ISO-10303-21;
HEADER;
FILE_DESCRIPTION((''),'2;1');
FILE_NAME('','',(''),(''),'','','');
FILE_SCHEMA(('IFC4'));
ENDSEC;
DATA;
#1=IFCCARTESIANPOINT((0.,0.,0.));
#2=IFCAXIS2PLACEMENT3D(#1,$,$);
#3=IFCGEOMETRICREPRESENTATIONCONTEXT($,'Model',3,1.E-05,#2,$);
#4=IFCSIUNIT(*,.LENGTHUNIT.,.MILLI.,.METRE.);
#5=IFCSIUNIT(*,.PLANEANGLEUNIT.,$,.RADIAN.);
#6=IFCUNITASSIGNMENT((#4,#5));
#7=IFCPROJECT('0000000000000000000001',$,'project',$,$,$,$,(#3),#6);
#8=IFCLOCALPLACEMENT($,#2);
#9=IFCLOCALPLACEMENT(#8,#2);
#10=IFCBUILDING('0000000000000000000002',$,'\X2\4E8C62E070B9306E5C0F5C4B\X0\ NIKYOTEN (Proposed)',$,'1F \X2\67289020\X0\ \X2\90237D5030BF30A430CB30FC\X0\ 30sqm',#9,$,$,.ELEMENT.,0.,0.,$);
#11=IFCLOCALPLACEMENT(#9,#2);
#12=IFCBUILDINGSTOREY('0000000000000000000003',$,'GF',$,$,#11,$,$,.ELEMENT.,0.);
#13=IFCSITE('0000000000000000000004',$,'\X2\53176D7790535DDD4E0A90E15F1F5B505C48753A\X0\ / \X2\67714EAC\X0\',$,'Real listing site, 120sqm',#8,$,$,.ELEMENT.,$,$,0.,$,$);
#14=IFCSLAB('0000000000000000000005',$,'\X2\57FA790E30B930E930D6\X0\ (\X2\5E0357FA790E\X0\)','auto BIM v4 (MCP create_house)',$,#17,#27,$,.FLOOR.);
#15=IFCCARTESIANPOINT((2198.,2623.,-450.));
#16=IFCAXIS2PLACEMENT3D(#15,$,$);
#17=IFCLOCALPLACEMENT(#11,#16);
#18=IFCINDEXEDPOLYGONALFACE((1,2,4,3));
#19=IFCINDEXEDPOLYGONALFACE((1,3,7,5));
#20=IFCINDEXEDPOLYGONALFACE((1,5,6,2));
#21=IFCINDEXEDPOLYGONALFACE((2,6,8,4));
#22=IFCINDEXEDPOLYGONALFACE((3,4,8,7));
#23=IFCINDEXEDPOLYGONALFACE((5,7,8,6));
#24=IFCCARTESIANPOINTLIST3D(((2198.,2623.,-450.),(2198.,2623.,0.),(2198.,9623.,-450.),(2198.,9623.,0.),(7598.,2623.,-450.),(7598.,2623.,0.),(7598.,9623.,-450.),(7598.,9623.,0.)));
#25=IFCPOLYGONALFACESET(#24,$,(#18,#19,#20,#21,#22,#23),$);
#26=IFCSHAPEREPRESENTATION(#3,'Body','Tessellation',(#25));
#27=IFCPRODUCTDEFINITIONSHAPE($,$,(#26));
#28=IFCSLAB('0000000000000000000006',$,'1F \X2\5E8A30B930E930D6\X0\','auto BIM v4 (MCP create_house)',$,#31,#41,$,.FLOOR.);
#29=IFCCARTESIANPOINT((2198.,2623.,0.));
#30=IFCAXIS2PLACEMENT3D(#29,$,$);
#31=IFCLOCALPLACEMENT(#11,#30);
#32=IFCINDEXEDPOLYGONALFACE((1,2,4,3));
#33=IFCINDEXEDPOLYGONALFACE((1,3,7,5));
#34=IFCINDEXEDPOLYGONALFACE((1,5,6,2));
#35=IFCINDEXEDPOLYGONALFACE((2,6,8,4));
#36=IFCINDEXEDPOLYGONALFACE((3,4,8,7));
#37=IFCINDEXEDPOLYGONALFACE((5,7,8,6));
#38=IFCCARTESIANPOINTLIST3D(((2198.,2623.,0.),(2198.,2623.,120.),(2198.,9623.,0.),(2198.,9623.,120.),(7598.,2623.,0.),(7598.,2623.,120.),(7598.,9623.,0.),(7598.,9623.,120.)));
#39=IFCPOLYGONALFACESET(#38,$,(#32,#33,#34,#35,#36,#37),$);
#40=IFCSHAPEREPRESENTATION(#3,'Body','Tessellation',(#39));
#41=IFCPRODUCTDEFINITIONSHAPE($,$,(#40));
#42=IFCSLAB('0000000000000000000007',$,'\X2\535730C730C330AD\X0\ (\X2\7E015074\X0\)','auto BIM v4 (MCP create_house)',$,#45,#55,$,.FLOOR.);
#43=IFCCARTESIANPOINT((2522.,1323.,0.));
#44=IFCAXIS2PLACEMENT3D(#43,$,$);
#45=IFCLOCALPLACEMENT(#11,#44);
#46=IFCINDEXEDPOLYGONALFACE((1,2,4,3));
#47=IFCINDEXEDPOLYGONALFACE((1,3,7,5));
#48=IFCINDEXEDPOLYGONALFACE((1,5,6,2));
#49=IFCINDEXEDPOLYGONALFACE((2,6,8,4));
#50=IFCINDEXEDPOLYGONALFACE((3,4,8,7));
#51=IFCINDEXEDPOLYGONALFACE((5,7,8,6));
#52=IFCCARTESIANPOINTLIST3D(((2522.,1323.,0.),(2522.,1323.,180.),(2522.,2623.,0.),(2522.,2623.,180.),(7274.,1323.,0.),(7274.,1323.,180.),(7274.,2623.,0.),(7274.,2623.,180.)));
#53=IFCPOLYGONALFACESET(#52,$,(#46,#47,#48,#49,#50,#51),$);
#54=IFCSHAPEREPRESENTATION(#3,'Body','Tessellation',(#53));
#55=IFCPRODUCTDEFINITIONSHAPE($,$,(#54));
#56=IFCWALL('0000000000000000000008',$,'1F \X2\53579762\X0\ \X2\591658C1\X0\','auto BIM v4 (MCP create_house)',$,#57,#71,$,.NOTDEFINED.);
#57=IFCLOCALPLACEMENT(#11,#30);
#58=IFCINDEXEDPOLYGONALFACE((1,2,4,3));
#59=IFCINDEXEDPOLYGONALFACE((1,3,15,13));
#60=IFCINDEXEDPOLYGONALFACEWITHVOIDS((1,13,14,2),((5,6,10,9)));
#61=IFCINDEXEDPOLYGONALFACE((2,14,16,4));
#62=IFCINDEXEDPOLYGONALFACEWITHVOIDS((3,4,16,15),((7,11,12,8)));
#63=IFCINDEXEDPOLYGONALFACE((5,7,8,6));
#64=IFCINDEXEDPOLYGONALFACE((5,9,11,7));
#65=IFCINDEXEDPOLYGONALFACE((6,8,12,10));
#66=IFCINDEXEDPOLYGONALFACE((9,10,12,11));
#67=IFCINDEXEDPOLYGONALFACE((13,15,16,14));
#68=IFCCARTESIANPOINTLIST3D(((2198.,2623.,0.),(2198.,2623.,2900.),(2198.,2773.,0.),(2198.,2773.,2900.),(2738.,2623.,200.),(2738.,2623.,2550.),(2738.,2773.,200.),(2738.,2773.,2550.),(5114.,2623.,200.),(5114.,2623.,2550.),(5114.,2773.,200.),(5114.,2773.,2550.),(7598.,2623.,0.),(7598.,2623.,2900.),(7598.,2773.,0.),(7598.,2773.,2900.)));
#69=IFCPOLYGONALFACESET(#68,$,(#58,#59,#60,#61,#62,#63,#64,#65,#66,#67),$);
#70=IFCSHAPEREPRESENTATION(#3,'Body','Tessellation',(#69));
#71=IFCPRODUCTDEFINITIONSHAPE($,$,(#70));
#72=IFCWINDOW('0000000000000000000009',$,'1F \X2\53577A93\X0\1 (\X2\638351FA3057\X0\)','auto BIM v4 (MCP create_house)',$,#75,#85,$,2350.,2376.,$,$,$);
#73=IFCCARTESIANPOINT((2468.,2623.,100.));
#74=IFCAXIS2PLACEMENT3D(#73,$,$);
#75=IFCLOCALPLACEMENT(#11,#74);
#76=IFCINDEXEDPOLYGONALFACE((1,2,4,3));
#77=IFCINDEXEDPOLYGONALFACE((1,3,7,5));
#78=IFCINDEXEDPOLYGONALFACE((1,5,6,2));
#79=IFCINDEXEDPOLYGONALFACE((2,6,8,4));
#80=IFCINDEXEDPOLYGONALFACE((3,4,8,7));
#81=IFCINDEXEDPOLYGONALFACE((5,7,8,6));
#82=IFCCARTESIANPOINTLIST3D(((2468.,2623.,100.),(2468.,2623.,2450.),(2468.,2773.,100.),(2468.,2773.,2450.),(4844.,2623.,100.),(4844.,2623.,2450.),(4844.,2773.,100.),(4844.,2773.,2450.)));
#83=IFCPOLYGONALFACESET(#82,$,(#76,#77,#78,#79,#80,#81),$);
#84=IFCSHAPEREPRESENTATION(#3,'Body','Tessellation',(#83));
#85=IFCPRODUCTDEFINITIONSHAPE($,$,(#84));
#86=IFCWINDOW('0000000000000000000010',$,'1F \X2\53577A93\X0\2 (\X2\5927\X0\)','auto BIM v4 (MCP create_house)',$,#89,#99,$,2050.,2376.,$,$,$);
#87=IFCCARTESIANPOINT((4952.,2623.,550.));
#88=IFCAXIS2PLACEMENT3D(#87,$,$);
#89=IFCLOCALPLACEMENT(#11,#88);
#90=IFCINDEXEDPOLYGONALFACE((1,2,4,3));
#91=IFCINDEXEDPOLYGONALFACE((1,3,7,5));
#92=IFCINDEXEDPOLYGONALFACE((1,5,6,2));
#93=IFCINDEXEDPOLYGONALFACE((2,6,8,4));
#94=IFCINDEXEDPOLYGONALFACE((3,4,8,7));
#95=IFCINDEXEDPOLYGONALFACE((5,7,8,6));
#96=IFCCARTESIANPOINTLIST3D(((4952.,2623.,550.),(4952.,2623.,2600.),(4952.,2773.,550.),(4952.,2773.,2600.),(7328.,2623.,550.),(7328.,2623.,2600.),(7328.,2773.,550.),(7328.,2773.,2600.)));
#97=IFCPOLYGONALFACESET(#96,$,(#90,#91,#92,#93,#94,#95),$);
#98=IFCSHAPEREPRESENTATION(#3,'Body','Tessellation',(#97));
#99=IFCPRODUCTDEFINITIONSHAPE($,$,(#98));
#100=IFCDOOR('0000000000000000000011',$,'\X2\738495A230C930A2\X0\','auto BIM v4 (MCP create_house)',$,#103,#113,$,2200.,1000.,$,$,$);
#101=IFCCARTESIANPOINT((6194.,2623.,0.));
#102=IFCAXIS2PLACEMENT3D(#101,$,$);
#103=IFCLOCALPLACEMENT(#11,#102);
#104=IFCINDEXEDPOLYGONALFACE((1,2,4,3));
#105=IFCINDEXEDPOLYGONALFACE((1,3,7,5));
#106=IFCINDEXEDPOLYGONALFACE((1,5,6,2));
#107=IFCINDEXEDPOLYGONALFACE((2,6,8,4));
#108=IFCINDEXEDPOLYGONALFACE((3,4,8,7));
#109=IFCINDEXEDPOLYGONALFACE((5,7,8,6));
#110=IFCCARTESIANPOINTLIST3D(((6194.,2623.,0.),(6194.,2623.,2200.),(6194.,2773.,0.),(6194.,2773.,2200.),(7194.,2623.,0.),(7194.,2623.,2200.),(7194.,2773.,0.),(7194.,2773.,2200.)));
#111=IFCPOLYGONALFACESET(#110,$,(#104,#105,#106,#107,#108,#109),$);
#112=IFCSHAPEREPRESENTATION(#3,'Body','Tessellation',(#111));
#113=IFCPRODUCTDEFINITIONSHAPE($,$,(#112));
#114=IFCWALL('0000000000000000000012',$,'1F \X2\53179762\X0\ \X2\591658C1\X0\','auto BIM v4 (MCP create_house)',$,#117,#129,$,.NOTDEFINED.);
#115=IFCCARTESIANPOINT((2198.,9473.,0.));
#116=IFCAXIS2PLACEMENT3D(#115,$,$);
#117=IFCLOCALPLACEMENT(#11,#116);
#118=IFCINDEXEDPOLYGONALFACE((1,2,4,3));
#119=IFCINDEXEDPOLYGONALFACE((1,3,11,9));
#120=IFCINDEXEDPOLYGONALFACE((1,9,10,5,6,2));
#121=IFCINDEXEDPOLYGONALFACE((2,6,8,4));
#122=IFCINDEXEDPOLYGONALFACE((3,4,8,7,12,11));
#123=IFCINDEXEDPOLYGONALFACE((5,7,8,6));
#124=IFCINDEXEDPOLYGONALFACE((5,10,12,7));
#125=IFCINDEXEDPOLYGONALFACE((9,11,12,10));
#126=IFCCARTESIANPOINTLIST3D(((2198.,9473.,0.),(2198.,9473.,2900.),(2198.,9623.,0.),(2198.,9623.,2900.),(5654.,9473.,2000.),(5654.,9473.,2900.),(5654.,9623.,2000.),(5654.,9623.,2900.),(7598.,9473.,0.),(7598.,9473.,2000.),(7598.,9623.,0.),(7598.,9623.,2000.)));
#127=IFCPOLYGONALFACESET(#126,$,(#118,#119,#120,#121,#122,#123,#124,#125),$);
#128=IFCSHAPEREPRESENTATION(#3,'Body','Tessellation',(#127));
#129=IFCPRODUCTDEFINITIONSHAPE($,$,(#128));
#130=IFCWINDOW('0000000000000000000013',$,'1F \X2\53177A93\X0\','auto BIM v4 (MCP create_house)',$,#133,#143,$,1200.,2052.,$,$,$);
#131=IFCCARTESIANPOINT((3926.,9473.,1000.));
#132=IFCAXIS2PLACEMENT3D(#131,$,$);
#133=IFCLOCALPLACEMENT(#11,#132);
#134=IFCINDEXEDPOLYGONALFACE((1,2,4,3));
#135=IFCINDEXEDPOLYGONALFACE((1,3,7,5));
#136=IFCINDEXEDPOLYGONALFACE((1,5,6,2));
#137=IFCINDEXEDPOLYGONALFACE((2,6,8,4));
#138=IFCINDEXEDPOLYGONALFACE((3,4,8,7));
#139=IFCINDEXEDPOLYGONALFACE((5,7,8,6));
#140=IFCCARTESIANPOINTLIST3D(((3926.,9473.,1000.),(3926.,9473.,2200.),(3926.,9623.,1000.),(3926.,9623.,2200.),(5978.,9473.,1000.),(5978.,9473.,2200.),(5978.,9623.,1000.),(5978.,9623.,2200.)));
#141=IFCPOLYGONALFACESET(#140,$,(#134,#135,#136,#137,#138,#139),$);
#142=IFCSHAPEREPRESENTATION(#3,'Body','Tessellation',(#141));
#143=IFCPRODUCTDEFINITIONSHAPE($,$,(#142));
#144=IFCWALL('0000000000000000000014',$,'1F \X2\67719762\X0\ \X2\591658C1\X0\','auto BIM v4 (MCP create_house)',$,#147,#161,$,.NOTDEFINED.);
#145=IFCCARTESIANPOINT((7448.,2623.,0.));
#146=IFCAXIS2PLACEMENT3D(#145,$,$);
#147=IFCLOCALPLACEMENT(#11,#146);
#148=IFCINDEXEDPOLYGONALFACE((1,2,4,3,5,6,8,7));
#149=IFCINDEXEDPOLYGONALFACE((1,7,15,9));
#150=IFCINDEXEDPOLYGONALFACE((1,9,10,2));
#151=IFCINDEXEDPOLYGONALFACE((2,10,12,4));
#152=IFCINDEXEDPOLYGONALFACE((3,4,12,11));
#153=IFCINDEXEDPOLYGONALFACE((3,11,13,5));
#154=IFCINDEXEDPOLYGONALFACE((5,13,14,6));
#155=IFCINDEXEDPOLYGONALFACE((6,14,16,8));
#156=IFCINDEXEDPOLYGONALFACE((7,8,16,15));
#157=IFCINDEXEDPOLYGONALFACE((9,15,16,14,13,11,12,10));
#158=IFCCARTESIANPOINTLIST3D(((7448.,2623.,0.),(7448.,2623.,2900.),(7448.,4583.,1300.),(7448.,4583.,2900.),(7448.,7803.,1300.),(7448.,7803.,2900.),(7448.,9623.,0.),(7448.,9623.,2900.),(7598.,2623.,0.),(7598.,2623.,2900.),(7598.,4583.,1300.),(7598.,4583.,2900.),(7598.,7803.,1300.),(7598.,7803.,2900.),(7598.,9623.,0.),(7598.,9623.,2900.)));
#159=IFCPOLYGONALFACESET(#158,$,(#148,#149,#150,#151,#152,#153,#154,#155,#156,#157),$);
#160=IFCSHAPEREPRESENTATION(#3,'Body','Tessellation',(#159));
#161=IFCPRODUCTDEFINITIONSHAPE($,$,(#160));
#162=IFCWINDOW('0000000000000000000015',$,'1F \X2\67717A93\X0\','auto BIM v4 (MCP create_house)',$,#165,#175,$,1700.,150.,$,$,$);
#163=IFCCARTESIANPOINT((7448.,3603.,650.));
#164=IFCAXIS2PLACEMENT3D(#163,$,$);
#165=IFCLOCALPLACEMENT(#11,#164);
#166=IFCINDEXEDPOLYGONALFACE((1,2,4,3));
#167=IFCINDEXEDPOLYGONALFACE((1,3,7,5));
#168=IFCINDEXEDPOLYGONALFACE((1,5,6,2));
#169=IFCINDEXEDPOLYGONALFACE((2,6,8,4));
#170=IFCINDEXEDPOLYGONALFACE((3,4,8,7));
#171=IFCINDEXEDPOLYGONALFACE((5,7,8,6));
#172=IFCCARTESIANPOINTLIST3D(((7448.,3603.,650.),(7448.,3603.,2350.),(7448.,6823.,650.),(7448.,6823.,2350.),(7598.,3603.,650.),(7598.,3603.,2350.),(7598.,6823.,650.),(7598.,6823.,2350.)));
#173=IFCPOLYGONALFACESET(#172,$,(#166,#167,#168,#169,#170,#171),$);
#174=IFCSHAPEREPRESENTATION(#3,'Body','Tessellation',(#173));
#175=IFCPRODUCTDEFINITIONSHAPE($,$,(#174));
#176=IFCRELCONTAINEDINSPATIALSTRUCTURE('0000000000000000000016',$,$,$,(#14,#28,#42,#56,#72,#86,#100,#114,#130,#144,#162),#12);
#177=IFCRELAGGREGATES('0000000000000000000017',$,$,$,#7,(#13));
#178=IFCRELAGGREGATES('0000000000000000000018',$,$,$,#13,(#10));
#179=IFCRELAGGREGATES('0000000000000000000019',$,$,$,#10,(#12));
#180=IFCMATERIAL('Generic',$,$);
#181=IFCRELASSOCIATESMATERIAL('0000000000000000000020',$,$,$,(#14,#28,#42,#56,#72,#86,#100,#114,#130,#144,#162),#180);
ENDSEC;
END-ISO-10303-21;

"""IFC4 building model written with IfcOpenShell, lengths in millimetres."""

from ifc_helpers import new_model, si_unit, frame, frame_2d, origin, place, context, project, spatial, rectangle, extrude, material, element, fill, save


model = new_model("IFC4")

# Units and contexts
model_context = context("Model", 3, precision=1e-05, world=origin())
ifc_project = project(units=[si_unit("LENGTHUNIT", "METRE", prefix="MILLI"), si_unit("PLANEANGLEUNIT", "RADIAN")], contexts=[model_context])

# Site, building, storey
site_placement = place(None, origin())
site = spatial("IfcSite", under=ifc_project, at=site_placement, Name="北海道川上郡弟子屈町 / 東京", ObjectType="Real listing site, 120sqm", CompositionType="ELEMENT", RefElevation=0.0)
building_placement = place(site_placement, origin())
building = spatial("IfcBuilding", under=site, at=building_placement, Name="二拠点の小屋 NIKYOTEN (Proposed)", ObjectType="1F 木造 連結タイニー 30sqm", CompositionType="ELEMENT", ElevationOfRefHeight=0.0, ElevationOfTerrain=0.0)
storey_placement = place(building_placement, origin())
storey = spatial("IfcBuildingStorey", under=building, at=storey_placement, Name="GF", CompositionType="ELEMENT", Elevation=0.0)

# Slabs
ifc_material = material(Name="Generic")
slab_1_placement = place(storey_placement, frame((2198.0, 2623.0, -450.0)))
element("IfcSlab", 1, at=slab_1_placement, inside=storey, material=ifc_material, Name="基礎スラブ (布基礎)", Description="auto BIM v4 (MCP create_house)", PredefinedType="FLOOR", context=model_context, shape_type="SweptSolid", body=[
    extrude(rectangle(XDim=5400.0, YDim=7000.0, at=frame_2d((2700.0, 3500.0))), frame((2198.0, 2623.0, -450.0)), (0.0, 0.0, 1.0), 450.0),
])
slab_2_placement = place(storey_placement, frame((2198.0, 2623.0, 0.0)))
element("IfcSlab", 2, at=slab_2_placement, inside=storey, material=ifc_material, Name="1F 床スラブ", Description="auto BIM v4 (MCP create_house)", PredefinedType="FLOOR", context=model_context, shape_type="SweptSolid", body=[
    extrude(rectangle(XDim=5400.0, YDim=7000.0, at=frame_2d((2700.0, 3500.0))), frame((2198.0, 2623.0, 0.0)), (0.0, 0.0, 1.0), 120.0),
])
slab_3_placement = place(storey_placement, frame((2522.0, 1323.0, 0.0)))
element("IfcSlab", 3, at=slab_3_placement, inside=storey, material=ifc_material, Name="南デッキ (縁側)", Description="auto BIM v4 (MCP create_house)", PredefinedType="FLOOR", context=model_context, shape_type="SweptSolid", body=[
    extrude(rectangle(XDim=4752.0, YDim=1300.0, at=frame_2d((2376.0, 650.0))), frame((2522.0, 1323.0, 0.0)), (0.0, 0.0, 1.0), 180.0),
])

# Wall, openings, windows, door
wall_1_placement = place(storey_placement, frame((2198.0, 2623.0, 0.0)))
wall_1 = element("IfcWall", 4, at=wall_1_placement, inside=storey, material=ifc_material, Name="1F 南面 外壁", Description="auto BIM v4 (MCP create_house)", PredefinedType="NOTDEFINED", context=model_context, shape_type="SweptSolid", body=[
    extrude(rectangle(XDim=5400.0, YDim=150.0, at=frame_2d((2700.0, 75.0))), frame((2198.0, 2623.0, 0.0)), (0.0, 0.0, 1.0), 2900.0),
])
opening_1_placement = place(storey_placement, frame((2468.0, 2623.0, 100.0)))
opening_1 = element("IfcOpeningElement", 5, at=opening_1_placement, cuts=wall_1, PredefinedType="NOTDEFINED", context=model_context, shape_type="SweptSolid", body=[
    extrude(rectangle(XDim=2376.0, YDim=150.0, at=frame_2d((1188.0, 75.0))), frame((2468.0, 2623.0, 100.0)), (0.0, 0.0, 1.0), 2350.0),
])
opening_2_placement = place(storey_placement, frame((4952.0, 2623.0, 550.0)))
opening_2 = element("IfcOpeningElement", 6, at=opening_2_placement, cuts=wall_1, PredefinedType="NOTDEFINED", context=model_context, shape_type="SweptSolid", body=[
    extrude(rectangle(XDim=2376.0, YDim=150.0, at=frame_2d((1188.0, 75.0))), frame((4952.0, 2623.0, 550.0)), (0.0, 0.0, 1.0), 2050.0),
])
opening_3_placement = place(storey_placement, frame((6194.0, 2623.0, 0.0)))
opening_3 = element("IfcOpeningElement", 7, at=opening_3_placement, cuts=wall_1, PredefinedType="NOTDEFINED", context=model_context, shape_type="SweptSolid", body=[
    extrude(rectangle(XDim=1000.0, YDim=150.0, at=frame_2d((500.0, 75.0))), frame((6194.0, 2623.0, 0.0)), (0.0, 0.0, 1.0), 2200.0),
])
window_1_placement = place(storey_placement, frame((2468.0, 2623.0, 100.0)))
window_1 = element("IfcWindow", 8, at=window_1_placement, inside=storey, material=ifc_material, Name="1F 南窓1 (掃出し)", Description="auto BIM v4 (MCP create_house)", OverallHeight=2350.0, OverallWidth=2376.0, context=model_context, shape_type="SweptSolid", body=[
    extrude(rectangle(XDim=2376.0, YDim=150.0, at=frame_2d((1188.0, 75.0))), frame((2468.0, 2623.0, 100.0)), (0.0, 0.0, 1.0), 2350.0),
])
fill(opening_1, window_1)
window_2_placement = place(storey_placement, frame((4952.0, 2623.0, 550.0)))
window_2 = element("IfcWindow", 9, at=window_2_placement, inside=storey, material=ifc_material, Name="1F 南窓2 (大)", Description="auto BIM v4 (MCP create_house)", OverallHeight=2050.0, OverallWidth=2376.0, context=model_context, shape_type="SweptSolid", body=[
    extrude(rectangle(XDim=2376.0, YDim=150.0, at=frame_2d((1188.0, 75.0))), frame((4952.0, 2623.0, 550.0)), (0.0, 0.0, 1.0), 2050.0),
])
fill(opening_2, window_2)
door_placement = place(storey_placement, frame((6194.0, 2623.0, 0.0)))
door = element("IfcDoor", 10, at=door_placement, inside=storey, material=ifc_material, Name="玄関ドア", Description="auto BIM v4 (MCP create_house)", OverallHeight=2200.0, OverallWidth=1000.0, context=model_context, shape_type="SweptSolid", body=[
    extrude(rectangle(XDim=1000.0, YDim=150.0, at=frame_2d((500.0, 75.0))), frame((6194.0, 2623.0, 0.0)), (0.0, 0.0, 1.0), 2200.0),
])
fill(opening_3, door)

# Walls, openings, windows
wall_2_placement = place(storey_placement, frame((2198.0, 9473.0, 0.0)))
wall_2 = element("IfcWall", 11, at=wall_2_placement, inside=storey, material=ifc_material, Name="1F 北面 外壁", Description="auto BIM v4 (MCP create_house)", PredefinedType="NOTDEFINED", context=model_context, shape_type="SweptSolid", body=[
    extrude(rectangle(XDim=5400.0, YDim=150.0, at=frame_2d((2700.0, 75.0))), frame((2198.0, 9473.0, 0.0)), (0.0, 0.0, 1.0), 2900.0),
])
opening_4_placement = place(storey_placement, frame((3926.0, 9473.0, 1000.0)))
opening_4 = element("IfcOpeningElement", 12, at=opening_4_placement, cuts=wall_2, PredefinedType="NOTDEFINED", context=model_context, shape_type="SweptSolid", body=[
    extrude(rectangle(XDim=2052.0, YDim=150.0, at=frame_2d((1026.0, 75.0))), frame((3926.0, 9473.0, 1000.0)), (0.0, 0.0, 1.0), 1200.0),
])
window_3_placement = place(storey_placement, frame((3926.0, 9473.0, 1000.0)))
window_3 = element("IfcWindow", 13, at=window_3_placement, inside=storey, material=ifc_material, Name="1F 北窓", Description="auto BIM v4 (MCP create_house)", OverallHeight=1200.0, OverallWidth=2052.0, context=model_context, shape_type="SweptSolid", body=[
    extrude(rectangle(XDim=2052.0, YDim=150.0, at=frame_2d((1026.0, 75.0))), frame((3926.0, 9473.0, 1000.0)), (0.0, 0.0, 1.0), 1200.0),
])
fill(opening_4, window_3)
wall_3_placement = place(storey_placement, frame((7448.0, 2623.0, 0.0)))
wall_3 = element("IfcWall", 14, at=wall_3_placement, inside=storey, material=ifc_material, Name="1F 東面 外壁", Description="auto BIM v4 (MCP create_house)", PredefinedType="NOTDEFINED", context=model_context, shape_type="SweptSolid", body=[
    extrude(rectangle(XDim=150.0, YDim=7000.0, at=frame_2d((75.0, 3500.0))), frame((7448.0, 2623.0, 0.0)), (0.0, 0.0, 1.0), 2900.0),
])
opening_5_placement = place(storey_placement, frame((7448.0, 3603.0, 650.0)))
opening_5 = element("IfcOpeningElement", 15, at=opening_5_placement, cuts=wall_3, PredefinedType="NOTDEFINED", context=model_context, shape_type="SweptSolid", body=[
    extrude(rectangle(XDim=150.0, YDim=3220.0, at=frame_2d((75.0, 1610.0))), frame((7448.0, 3603.0, 650.0)), (0.0, 0.0, 1.0), 1700.0),
])
window_4_placement = place(storey_placement, frame((7448.0, 3603.0, 650.0)))
window_4 = element("IfcWindow", 16, at=window_4_placement, inside=storey, material=ifc_material, Name="1F 東窓", Description="auto BIM v4 (MCP create_house)", OverallHeight=1700.0, OverallWidth=150.0, context=model_context, shape_type="SweptSolid", body=[
    extrude(rectangle(XDim=150.0, YDim=3220.0, at=frame_2d((75.0, 1610.0))), frame((7448.0, 3603.0, 650.0)), (0.0, 0.0, 1.0), 1700.0),
])
fill(opening_5, window_4)

save(model, "model.ifc")
